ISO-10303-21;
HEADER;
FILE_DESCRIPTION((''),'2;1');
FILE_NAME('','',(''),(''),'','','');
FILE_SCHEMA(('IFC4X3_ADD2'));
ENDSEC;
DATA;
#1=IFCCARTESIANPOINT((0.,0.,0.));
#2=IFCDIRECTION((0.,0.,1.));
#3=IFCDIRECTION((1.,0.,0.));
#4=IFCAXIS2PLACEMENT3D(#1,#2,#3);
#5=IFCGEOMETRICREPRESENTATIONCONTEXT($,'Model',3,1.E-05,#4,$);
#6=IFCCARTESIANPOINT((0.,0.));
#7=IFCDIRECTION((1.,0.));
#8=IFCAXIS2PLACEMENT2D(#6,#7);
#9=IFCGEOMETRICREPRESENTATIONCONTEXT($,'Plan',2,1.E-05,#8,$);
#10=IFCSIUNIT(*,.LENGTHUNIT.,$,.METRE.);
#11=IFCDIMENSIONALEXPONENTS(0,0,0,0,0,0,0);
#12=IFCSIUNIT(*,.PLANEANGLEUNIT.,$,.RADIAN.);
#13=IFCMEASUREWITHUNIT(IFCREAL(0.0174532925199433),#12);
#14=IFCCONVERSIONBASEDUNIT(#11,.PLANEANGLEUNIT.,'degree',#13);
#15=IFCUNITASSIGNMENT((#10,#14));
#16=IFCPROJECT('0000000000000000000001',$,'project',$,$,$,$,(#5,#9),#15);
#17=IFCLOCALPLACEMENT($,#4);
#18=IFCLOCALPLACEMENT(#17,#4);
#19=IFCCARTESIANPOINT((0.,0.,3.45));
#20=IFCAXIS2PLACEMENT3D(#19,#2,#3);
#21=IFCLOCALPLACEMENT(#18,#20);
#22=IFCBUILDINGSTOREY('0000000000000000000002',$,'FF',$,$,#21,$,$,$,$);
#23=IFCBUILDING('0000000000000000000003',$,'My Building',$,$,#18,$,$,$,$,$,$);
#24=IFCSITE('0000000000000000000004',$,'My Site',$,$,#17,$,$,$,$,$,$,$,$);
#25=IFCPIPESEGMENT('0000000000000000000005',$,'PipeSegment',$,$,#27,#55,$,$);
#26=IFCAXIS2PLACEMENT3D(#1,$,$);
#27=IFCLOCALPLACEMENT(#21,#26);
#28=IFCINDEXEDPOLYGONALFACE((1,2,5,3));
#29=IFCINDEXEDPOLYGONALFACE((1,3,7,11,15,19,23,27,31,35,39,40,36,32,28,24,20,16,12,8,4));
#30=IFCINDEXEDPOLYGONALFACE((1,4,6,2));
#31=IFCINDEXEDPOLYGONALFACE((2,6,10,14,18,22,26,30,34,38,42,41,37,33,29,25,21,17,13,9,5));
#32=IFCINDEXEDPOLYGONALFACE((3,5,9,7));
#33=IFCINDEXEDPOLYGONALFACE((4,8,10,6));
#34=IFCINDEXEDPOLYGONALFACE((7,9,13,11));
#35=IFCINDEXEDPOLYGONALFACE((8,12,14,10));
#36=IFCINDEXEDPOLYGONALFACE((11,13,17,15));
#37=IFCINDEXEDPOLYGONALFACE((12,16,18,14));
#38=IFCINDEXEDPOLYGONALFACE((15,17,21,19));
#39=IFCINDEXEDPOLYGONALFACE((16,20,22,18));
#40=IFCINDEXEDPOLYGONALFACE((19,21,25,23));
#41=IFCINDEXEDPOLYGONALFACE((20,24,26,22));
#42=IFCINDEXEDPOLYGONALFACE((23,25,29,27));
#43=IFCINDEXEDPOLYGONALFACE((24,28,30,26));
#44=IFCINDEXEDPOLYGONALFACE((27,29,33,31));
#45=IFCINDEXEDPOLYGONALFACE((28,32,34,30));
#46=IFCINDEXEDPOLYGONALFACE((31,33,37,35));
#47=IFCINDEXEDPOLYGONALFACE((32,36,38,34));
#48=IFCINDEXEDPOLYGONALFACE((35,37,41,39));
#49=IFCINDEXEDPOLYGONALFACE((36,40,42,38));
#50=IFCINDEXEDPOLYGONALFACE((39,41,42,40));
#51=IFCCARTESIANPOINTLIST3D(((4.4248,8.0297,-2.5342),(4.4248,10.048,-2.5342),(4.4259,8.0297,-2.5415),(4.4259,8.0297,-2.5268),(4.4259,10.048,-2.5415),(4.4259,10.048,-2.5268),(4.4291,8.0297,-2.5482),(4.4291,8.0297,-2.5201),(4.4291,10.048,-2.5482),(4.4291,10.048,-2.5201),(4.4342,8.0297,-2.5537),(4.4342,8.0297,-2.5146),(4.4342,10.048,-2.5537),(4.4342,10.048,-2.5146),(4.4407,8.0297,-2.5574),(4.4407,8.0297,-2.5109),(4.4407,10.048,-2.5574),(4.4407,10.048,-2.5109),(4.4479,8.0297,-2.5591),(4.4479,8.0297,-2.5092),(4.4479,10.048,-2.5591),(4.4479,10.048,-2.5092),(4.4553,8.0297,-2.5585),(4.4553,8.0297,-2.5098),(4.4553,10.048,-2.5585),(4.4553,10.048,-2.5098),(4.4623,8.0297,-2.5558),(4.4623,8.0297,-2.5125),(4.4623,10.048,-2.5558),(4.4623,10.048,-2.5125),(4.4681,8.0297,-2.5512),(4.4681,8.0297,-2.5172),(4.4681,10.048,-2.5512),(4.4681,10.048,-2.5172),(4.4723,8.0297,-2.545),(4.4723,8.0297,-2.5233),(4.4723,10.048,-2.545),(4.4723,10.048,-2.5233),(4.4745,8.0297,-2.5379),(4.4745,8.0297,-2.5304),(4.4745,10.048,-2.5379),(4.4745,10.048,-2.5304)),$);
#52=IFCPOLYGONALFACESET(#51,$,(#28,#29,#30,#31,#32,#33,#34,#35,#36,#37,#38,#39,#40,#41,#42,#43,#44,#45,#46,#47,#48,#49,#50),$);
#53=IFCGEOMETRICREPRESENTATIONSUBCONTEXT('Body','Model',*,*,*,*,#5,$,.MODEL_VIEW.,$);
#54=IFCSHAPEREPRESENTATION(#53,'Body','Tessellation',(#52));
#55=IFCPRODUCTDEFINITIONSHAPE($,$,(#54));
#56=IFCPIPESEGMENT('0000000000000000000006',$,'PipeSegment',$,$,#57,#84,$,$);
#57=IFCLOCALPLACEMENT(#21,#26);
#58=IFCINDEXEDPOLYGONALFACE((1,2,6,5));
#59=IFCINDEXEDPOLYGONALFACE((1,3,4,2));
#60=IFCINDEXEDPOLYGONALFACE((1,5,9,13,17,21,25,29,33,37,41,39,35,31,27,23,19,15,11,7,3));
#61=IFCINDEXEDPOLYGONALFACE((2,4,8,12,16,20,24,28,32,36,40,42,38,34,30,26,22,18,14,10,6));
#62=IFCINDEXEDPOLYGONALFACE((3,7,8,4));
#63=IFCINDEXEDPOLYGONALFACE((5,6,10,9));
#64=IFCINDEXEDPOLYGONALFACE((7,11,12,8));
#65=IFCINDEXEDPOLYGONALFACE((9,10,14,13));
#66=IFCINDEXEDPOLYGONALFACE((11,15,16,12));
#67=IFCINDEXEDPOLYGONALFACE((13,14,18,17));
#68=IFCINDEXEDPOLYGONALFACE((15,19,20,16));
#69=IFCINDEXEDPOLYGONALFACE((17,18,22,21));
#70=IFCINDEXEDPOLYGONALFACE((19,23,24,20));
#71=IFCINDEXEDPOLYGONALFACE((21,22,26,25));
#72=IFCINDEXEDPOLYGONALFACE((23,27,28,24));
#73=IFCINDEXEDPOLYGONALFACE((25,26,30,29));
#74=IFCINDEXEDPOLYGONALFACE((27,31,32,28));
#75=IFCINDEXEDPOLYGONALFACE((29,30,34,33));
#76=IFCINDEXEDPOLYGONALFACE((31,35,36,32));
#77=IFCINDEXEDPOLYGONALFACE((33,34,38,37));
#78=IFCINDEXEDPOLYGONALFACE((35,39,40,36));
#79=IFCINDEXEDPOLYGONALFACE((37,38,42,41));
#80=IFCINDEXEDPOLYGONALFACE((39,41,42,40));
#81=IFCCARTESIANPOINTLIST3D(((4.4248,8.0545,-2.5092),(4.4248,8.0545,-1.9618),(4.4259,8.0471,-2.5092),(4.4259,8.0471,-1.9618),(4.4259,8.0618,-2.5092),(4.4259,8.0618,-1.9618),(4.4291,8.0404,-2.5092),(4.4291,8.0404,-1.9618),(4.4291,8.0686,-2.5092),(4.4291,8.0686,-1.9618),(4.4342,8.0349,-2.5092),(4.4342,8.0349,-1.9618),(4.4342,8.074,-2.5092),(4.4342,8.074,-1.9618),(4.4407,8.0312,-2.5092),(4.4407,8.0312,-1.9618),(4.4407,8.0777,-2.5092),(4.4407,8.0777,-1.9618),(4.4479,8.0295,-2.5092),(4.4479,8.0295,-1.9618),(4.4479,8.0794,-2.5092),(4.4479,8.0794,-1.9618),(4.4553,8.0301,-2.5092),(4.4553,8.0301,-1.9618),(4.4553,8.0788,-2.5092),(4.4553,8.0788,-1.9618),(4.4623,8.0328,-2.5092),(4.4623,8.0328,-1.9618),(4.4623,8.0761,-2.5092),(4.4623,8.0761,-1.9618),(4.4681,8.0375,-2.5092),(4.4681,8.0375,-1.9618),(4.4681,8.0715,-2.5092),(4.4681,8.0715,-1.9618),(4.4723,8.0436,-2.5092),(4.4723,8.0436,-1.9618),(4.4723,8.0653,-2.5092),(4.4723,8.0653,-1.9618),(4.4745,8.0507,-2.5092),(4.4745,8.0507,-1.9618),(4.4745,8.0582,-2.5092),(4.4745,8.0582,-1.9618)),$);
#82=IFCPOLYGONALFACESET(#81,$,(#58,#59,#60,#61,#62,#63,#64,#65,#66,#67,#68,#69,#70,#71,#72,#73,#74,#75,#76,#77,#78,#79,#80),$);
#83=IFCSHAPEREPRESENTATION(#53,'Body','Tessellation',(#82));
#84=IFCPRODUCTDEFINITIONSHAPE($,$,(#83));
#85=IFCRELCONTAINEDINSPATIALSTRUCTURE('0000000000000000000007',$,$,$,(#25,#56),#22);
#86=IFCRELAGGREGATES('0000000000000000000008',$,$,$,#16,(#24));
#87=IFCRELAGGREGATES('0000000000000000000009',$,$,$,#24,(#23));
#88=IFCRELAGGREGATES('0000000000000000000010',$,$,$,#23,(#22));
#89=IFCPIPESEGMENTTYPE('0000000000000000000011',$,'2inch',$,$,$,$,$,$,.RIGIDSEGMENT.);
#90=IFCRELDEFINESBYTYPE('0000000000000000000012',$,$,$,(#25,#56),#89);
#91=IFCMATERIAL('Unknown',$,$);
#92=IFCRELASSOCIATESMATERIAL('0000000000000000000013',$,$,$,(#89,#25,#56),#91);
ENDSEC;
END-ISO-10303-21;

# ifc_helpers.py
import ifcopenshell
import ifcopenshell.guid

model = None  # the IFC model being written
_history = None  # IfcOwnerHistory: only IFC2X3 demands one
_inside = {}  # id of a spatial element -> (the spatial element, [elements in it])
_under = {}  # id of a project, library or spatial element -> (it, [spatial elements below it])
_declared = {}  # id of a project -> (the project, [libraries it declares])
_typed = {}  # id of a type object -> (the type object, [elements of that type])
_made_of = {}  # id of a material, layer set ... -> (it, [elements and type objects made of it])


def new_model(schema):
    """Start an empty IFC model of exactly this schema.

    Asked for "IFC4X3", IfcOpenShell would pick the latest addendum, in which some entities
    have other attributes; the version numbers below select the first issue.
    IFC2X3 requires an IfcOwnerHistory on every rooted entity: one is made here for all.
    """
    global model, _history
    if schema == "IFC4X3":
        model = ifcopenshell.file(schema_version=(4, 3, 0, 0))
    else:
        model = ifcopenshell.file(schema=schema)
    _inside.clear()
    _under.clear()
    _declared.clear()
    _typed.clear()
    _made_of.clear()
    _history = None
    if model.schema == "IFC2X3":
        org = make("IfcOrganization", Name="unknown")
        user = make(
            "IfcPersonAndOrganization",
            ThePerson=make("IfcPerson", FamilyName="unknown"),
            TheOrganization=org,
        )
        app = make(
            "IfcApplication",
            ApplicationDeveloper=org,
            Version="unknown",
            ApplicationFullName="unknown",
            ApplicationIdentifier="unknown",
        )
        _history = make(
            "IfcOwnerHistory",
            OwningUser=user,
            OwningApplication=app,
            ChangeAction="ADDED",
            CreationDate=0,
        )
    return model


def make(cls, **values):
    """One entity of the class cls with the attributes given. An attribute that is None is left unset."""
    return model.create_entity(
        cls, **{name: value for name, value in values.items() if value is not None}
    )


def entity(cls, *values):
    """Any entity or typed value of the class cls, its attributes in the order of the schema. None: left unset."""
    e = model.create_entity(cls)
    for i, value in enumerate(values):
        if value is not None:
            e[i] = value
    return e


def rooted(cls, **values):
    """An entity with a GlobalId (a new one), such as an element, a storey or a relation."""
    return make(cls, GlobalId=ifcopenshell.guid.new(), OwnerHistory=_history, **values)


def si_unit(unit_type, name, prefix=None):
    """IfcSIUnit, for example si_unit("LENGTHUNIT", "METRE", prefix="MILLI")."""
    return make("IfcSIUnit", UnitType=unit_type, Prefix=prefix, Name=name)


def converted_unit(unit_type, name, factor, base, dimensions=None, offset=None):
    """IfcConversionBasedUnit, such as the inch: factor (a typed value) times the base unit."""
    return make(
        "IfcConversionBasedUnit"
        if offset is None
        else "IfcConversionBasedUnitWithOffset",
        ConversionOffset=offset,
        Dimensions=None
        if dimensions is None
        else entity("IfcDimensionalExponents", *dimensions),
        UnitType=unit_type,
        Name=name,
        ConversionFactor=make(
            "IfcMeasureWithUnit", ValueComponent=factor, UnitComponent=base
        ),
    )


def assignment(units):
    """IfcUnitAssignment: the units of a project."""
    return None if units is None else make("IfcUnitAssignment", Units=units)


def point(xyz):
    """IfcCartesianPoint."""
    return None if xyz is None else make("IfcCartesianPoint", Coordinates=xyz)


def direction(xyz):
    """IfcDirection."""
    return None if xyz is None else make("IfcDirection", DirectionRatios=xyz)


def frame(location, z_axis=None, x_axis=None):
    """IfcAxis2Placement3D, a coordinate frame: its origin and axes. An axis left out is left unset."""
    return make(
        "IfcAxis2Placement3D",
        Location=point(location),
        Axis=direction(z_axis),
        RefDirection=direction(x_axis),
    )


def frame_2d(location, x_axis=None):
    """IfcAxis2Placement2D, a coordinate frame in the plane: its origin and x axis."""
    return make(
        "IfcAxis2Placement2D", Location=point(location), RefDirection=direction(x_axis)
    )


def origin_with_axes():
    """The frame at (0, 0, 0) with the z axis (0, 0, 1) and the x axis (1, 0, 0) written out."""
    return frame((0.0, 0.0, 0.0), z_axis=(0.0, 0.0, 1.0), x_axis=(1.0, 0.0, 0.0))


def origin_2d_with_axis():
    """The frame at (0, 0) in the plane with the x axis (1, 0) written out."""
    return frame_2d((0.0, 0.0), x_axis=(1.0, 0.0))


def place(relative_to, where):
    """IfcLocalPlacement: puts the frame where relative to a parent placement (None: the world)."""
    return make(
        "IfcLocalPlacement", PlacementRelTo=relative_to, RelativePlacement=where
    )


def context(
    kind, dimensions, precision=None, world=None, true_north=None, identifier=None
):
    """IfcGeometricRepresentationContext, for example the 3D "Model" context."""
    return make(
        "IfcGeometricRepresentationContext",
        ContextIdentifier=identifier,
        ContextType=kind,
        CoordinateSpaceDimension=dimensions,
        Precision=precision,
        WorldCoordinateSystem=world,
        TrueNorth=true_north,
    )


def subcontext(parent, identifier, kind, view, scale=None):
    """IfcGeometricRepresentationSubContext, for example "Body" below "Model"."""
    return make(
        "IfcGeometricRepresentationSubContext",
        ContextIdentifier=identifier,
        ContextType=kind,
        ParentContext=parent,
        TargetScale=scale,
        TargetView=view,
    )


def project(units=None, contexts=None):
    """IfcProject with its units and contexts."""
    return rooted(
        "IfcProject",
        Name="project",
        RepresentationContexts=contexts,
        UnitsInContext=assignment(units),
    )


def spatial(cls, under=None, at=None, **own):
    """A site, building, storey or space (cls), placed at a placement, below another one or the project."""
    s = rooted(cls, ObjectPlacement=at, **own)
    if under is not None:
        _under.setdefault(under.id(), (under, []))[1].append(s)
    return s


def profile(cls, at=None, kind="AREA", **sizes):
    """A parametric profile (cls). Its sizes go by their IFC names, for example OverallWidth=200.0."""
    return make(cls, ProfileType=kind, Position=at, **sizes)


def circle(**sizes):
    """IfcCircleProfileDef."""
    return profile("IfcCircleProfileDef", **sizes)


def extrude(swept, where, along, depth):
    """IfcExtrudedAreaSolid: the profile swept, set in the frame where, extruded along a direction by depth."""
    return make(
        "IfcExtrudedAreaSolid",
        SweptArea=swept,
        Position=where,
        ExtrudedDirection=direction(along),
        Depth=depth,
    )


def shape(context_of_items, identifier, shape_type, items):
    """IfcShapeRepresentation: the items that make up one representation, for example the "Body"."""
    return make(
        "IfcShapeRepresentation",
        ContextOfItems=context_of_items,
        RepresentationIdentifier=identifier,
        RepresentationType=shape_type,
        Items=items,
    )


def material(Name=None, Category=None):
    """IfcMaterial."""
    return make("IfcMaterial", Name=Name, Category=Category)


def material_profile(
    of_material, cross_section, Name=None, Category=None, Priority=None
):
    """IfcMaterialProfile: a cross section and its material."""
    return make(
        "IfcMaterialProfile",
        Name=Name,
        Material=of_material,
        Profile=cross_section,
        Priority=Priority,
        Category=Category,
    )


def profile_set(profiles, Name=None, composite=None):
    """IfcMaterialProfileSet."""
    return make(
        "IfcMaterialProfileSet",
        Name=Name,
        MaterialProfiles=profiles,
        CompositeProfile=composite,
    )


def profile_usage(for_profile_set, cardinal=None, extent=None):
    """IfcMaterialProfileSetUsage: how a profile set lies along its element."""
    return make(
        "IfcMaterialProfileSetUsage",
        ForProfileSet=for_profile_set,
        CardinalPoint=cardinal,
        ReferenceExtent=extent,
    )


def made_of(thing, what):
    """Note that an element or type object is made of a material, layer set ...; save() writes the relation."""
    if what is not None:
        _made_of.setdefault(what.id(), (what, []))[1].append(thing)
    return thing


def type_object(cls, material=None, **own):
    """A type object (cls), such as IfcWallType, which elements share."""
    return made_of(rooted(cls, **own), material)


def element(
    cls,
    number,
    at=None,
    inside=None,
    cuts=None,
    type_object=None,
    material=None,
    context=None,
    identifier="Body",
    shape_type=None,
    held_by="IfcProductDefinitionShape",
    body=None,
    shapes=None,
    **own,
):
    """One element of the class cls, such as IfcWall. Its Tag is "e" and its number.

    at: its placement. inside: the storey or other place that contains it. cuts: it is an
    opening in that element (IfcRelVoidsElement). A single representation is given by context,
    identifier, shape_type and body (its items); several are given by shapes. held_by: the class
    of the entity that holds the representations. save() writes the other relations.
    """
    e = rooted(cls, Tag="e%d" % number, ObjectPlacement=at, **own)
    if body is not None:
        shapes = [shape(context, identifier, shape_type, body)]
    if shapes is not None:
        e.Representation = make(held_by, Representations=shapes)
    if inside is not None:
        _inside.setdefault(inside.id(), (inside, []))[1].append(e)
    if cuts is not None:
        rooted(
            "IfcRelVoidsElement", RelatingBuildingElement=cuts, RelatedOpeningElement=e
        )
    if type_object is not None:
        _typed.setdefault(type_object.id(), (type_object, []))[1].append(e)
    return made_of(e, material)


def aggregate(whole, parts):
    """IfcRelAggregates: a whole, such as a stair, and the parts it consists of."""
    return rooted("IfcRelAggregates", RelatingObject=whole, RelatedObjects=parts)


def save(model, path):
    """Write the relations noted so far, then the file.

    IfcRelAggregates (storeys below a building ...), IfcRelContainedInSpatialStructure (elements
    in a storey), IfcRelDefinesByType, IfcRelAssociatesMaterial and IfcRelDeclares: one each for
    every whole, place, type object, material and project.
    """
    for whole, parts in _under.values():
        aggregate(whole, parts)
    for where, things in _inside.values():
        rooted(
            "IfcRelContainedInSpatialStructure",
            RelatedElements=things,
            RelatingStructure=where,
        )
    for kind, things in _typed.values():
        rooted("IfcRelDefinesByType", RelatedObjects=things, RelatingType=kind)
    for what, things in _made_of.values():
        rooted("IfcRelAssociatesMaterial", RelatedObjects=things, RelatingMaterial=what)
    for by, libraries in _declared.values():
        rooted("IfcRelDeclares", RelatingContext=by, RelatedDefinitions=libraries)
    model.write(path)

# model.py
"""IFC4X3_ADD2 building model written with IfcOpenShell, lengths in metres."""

from ifc_helpers import new_model, entity, si_unit, converted_unit, frame, origin_with_axes, origin_2d_with_axis, place, context, subcontext, project, spatial, circle, extrude, material, material_profile, profile_set, profile_usage, type_object, element, save


model = new_model("IFC4X3_ADD2")

# Units and contexts
model_context = context("Model", 3, precision=1e-05, world=origin_with_axes())
plan_context = context("Plan", 2, precision=1e-05, world=origin_2d_with_axis())
body_context = subcontext(model_context, "Body", "Model", "MODEL_VIEW")
ifc_project = project(units=[si_unit("LENGTHUNIT", "METRE"), converted_unit("PLANEANGLEUNIT", "degree", entity("IfcReal", 0.0174532925199433), si_unit("PLANEANGLEUNIT", "RADIAN"), dimensions=[0, 0, 0, 0, 0, 0, 0])], contexts=[model_context, plan_context])

# Site, building, storey
site_placement = place(None, origin_with_axes())
site = spatial("IfcSite", under=ifc_project, at=site_placement, Name="My Site")
building_placement = place(site_placement, origin_with_axes())
building = spatial("IfcBuilding", under=site, at=building_placement, Name="My Building")
storey_placement = place(building_placement, frame((0.0, 0.0, 3.45), z_axis=(0.0, 0.0, 1.0), x_axis=(1.0, 0.0, 0.0)))
storey = spatial("IfcBuildingStorey", under=building, at=storey_placement, Name="FF")

# Shared definitions
ifc_material_1 = material(Name="Unknown")

# Pipe segments
ifc_material_profile_1 = material_profile(ifc_material_1, circle(Radius=0.025))
ifc_profile_set_1 = profile_set([ifc_material_profile_1])
pipe_segment_type_1 = type_object("IfcPipeSegmentType", Name="2inch", PredefinedType="RIGIDSEGMENT", material=ifc_profile_set_1)
ifc_profile_usage_1 = profile_usage(ifc_profile_set_1)
pipe_segment_1_placement = place(storey_placement, frame((4.4498, 8.0297, -2.5342), z_axis=(0.0, 1.0, 0.0), x_axis=(-1.0, 0.0, 0.0)))
element("IfcPipeSegment", 1, at=pipe_segment_1_placement, inside=storey, type_object=pipe_segment_type_1, material=ifc_profile_usage_1, Name="PipeSegment", context=body_context, shape_type="SweptSolid", body=[
    extrude(circle(Radius=0.025), origin_with_axes(), (0.0, 0.0, 1.0), 2.0184),
])
ifc_profile_usage_2 = profile_usage(ifc_profile_set_1)
pipe_segment_2_placement = place(storey_placement, frame((4.4498, 8.0545, -2.5092), z_axis=(0.0, 0.0, 1.0), x_axis=(-1.0, 0.0, 0.0)))
element("IfcPipeSegment", 2, at=pipe_segment_2_placement, inside=storey, type_object=pipe_segment_type_1, material=ifc_profile_usage_2, Name="PipeSegment", context=body_context, shape_type="SweptSolid", body=[
    extrude(circle(Radius=0.025), origin_with_axes(), (0.0, 0.0, 1.0), 0.5474),
])

save(model, "model.ifc")
